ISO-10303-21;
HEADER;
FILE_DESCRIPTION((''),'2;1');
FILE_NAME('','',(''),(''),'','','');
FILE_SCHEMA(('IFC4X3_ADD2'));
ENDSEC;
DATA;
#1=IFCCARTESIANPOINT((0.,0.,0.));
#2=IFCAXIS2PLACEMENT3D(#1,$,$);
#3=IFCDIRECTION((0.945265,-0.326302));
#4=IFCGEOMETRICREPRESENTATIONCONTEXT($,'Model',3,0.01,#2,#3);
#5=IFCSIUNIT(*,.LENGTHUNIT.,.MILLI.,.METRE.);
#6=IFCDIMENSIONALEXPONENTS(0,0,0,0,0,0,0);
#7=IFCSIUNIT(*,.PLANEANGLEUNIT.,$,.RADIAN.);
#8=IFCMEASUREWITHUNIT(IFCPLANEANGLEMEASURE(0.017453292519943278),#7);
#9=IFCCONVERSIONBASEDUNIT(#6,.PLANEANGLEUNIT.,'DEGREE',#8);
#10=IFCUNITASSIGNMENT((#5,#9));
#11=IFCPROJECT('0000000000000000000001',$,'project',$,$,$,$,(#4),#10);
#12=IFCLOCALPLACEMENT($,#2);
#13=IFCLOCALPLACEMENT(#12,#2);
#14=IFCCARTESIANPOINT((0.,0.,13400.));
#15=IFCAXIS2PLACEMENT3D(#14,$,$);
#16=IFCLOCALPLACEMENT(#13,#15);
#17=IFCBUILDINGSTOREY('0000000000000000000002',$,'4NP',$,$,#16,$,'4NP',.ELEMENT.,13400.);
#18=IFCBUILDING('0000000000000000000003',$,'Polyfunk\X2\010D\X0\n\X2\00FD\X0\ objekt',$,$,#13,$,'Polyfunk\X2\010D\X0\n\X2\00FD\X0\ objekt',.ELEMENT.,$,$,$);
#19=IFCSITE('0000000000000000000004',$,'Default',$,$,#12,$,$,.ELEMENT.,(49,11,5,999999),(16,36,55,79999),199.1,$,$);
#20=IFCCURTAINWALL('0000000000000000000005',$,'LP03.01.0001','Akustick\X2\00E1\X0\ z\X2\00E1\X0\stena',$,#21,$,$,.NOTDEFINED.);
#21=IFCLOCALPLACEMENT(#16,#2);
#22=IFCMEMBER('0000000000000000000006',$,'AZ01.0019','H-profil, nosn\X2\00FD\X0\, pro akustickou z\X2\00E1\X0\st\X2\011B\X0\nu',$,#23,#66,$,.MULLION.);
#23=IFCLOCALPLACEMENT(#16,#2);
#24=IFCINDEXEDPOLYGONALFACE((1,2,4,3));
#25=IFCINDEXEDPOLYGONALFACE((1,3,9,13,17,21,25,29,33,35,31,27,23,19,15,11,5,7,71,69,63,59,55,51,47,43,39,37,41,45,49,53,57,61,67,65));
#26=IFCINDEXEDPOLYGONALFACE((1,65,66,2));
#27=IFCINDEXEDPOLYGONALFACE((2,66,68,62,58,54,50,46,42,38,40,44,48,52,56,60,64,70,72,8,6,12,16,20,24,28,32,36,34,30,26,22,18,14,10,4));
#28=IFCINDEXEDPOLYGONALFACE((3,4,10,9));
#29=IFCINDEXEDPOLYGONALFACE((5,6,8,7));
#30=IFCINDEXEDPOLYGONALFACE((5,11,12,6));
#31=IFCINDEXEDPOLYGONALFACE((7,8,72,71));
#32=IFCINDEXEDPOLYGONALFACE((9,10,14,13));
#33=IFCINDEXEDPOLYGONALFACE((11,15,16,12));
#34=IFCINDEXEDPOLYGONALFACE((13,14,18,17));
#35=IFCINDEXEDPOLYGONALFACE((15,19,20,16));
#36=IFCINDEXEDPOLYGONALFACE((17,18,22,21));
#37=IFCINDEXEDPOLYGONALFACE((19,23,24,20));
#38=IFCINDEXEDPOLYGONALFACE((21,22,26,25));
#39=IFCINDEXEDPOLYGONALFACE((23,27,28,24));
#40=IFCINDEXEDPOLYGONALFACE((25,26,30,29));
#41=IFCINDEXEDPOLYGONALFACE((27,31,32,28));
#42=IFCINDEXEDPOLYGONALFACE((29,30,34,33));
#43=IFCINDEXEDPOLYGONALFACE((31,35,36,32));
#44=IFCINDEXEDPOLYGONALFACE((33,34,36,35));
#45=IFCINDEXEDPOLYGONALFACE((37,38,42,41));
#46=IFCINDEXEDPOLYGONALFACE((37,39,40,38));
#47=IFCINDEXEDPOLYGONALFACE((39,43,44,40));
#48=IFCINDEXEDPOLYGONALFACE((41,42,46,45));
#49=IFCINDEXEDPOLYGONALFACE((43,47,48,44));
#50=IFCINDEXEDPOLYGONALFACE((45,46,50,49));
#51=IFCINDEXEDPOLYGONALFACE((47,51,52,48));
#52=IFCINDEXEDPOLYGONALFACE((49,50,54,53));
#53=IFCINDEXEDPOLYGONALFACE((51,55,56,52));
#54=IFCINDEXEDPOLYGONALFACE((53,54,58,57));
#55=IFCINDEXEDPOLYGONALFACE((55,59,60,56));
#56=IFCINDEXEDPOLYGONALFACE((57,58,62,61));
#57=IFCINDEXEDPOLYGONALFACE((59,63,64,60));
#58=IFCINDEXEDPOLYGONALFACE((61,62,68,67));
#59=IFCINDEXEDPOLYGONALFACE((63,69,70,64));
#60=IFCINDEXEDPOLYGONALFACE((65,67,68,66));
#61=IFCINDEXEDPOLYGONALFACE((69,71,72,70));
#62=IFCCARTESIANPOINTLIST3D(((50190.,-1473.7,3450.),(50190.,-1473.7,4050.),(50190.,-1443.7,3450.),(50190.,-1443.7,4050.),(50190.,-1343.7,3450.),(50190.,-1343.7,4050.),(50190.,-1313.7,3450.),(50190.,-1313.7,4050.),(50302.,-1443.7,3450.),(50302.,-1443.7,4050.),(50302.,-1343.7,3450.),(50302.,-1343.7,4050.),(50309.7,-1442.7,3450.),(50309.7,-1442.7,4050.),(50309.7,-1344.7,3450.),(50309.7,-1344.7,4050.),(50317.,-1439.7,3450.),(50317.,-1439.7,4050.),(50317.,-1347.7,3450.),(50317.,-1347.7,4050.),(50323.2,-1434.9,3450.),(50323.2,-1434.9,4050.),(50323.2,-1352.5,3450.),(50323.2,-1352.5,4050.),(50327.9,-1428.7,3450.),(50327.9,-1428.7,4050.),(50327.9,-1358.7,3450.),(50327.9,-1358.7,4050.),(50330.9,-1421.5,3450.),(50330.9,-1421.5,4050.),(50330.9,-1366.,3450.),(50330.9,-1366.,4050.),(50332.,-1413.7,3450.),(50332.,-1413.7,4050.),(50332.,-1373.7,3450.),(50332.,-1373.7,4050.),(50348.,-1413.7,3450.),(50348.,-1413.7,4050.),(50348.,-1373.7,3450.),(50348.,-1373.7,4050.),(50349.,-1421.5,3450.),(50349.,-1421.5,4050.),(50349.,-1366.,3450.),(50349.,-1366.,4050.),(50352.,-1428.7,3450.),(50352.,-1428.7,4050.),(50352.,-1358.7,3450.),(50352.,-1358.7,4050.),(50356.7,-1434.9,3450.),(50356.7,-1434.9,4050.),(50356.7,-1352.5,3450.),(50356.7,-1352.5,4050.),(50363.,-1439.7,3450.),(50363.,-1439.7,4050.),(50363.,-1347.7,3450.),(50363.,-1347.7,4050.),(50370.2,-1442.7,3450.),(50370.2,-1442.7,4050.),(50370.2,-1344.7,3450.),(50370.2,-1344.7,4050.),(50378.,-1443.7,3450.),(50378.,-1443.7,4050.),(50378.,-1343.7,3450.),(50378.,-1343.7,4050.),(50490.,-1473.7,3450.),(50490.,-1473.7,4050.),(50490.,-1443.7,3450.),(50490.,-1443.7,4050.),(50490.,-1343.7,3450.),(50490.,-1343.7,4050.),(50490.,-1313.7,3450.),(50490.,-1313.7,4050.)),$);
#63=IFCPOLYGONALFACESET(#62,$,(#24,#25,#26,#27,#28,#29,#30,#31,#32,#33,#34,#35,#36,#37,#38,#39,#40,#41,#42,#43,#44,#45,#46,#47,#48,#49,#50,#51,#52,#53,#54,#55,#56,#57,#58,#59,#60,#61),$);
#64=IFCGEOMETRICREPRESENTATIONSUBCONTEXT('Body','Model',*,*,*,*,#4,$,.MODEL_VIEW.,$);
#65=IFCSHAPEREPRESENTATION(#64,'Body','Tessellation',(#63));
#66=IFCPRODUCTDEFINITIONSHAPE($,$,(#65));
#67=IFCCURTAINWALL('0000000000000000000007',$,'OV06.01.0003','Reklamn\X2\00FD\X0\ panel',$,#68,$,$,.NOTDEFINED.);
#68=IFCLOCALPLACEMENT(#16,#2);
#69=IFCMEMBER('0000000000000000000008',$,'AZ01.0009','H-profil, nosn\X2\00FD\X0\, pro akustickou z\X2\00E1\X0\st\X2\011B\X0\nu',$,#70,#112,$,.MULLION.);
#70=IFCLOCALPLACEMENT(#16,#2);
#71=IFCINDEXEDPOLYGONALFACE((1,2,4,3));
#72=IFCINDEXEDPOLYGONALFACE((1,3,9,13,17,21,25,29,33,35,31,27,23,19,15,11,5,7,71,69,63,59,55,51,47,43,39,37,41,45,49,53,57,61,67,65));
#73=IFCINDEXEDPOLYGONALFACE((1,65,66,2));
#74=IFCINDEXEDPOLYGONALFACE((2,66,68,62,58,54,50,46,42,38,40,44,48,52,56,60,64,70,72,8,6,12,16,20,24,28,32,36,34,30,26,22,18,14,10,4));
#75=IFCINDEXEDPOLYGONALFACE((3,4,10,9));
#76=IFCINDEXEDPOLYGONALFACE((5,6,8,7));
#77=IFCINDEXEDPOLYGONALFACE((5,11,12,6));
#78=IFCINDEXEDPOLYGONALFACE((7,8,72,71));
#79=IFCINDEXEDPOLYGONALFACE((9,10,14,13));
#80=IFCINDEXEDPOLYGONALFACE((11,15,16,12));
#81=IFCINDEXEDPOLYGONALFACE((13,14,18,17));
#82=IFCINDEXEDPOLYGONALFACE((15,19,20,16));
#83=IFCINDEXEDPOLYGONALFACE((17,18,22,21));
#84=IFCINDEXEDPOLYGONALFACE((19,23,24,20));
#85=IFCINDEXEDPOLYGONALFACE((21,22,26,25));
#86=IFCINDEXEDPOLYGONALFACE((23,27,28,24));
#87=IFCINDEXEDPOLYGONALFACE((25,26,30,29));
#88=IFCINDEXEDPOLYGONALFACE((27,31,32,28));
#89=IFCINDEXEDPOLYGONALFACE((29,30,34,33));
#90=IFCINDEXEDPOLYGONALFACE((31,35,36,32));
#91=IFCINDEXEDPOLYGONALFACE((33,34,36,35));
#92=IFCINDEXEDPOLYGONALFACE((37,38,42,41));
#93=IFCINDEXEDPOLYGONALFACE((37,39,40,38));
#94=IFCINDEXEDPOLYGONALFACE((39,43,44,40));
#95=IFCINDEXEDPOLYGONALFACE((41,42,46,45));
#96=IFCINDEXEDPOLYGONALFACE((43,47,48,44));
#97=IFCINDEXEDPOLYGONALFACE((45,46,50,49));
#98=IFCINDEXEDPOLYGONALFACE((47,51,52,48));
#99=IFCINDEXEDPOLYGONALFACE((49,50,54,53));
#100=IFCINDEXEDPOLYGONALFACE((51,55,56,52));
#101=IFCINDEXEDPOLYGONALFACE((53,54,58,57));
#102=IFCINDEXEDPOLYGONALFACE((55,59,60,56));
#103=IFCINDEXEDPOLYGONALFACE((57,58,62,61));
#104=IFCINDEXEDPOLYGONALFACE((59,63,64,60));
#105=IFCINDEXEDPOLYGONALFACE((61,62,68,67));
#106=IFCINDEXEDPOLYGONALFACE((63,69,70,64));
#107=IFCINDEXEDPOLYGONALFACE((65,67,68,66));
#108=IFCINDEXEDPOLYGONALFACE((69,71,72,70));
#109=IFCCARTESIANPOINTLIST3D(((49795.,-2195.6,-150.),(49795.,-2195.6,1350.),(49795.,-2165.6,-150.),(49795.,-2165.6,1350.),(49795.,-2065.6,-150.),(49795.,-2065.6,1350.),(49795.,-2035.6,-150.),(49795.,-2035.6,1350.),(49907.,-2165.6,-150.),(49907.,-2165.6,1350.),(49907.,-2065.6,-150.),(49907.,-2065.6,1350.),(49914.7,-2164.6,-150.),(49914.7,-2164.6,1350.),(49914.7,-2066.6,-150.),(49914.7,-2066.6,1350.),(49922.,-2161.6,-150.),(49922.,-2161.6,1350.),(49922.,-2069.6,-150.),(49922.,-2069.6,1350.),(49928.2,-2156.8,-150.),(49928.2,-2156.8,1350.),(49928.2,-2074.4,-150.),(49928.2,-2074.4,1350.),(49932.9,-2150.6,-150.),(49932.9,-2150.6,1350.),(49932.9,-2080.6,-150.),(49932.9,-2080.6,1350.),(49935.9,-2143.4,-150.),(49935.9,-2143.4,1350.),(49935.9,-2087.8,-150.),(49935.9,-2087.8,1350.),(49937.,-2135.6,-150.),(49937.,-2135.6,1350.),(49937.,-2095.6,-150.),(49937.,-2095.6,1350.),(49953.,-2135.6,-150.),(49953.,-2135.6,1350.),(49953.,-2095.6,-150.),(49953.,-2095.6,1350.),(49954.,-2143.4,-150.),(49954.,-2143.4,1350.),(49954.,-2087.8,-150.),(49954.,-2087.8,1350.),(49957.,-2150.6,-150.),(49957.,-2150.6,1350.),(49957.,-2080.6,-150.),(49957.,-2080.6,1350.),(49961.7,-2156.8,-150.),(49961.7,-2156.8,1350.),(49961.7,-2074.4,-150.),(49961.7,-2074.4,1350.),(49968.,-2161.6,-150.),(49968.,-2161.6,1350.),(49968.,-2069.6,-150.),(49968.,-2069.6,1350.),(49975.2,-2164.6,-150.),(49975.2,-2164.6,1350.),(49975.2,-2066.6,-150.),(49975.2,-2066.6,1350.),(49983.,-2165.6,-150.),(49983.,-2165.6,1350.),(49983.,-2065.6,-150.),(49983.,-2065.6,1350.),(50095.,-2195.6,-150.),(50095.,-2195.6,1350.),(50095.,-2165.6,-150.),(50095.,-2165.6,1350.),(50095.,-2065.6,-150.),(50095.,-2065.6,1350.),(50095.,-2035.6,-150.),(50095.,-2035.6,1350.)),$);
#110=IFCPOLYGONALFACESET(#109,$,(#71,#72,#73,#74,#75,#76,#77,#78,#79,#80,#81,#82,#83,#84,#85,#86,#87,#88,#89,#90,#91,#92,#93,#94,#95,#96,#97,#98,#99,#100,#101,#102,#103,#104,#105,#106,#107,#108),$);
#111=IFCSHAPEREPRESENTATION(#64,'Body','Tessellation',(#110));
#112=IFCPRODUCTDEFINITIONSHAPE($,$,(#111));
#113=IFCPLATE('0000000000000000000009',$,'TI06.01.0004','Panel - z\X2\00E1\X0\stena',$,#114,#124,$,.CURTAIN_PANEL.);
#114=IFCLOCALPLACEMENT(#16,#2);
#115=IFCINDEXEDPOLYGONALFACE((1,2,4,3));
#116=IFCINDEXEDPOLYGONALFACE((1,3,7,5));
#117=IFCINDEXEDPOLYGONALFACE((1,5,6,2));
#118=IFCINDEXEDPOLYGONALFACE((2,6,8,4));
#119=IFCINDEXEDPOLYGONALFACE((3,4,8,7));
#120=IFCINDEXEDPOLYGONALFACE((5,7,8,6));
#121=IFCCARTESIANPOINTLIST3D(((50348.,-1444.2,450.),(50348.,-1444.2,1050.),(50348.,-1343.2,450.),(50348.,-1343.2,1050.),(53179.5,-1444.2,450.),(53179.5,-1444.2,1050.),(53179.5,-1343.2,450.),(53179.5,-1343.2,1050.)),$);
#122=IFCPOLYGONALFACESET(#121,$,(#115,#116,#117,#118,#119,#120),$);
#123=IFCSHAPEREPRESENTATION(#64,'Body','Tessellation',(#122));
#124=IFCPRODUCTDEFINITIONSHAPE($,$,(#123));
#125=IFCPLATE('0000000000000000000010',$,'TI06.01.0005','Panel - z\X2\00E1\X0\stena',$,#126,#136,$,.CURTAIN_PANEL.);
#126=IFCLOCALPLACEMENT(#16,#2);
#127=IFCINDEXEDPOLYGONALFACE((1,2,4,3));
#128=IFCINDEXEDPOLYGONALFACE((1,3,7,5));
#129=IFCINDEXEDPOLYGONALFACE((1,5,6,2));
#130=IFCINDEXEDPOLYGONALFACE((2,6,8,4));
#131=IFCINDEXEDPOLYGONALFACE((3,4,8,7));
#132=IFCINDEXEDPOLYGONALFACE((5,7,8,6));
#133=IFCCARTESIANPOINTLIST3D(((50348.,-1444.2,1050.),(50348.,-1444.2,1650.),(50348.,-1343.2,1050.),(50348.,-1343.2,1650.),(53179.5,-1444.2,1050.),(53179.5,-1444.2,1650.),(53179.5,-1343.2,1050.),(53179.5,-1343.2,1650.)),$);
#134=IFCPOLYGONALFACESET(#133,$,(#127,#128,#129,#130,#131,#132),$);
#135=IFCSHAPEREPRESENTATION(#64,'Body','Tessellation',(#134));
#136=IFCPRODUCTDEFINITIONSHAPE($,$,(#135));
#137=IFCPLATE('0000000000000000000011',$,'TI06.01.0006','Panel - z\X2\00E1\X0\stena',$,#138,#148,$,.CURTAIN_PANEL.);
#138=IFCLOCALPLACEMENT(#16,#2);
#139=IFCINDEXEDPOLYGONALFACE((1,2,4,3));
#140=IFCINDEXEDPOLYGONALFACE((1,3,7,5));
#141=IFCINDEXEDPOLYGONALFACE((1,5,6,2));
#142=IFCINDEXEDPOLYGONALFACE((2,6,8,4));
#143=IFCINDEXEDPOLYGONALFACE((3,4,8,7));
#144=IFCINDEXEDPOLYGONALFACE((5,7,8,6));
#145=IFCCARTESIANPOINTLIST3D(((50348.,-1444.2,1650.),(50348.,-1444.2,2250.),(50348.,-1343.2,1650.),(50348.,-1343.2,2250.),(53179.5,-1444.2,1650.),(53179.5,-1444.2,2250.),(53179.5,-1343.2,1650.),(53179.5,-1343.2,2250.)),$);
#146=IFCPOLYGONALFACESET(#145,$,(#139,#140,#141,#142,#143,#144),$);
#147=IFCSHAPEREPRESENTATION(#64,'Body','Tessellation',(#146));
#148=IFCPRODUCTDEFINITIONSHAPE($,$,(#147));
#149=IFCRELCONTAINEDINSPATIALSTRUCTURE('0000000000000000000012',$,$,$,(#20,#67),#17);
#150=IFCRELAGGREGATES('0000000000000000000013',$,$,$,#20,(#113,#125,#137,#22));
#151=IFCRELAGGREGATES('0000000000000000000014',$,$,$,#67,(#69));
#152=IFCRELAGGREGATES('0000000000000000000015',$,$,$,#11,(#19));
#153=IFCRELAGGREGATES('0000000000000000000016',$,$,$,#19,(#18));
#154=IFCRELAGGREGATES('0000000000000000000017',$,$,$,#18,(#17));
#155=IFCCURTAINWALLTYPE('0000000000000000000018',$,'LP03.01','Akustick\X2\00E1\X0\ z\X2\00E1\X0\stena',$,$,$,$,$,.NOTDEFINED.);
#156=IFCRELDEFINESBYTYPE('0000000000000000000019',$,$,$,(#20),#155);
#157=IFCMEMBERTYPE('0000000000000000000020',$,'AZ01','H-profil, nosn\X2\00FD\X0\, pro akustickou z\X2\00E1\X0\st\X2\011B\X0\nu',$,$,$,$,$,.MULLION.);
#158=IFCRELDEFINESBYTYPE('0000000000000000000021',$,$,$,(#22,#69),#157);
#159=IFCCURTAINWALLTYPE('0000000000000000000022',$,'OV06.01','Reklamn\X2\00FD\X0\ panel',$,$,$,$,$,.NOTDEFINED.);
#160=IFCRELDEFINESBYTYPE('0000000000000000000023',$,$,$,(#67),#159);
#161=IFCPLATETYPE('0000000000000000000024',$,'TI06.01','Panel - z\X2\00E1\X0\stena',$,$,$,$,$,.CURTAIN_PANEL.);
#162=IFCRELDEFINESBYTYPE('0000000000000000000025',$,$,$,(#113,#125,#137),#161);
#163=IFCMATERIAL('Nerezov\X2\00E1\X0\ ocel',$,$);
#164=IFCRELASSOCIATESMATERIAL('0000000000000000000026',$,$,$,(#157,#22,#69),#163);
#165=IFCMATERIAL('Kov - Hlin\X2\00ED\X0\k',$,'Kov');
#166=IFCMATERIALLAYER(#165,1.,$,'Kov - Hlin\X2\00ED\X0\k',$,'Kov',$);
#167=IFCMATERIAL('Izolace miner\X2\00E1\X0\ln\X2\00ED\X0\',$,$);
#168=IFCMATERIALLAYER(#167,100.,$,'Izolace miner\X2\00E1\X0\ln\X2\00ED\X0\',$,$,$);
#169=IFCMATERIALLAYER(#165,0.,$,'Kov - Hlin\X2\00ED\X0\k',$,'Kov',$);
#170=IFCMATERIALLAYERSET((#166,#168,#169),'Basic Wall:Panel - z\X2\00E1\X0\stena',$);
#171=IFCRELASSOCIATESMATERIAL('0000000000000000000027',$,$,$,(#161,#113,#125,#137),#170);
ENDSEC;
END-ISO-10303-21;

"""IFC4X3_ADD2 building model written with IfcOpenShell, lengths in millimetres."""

from ifc_helpers import new_model, entity, si_unit, converted_unit, direction, frame, frame_2d, origin, place, context, subcontext, project, spatial, polyline, circle_curve, parameter, trimmed, segment, composite_curve, rectangle, outline, extrude, source, transform, mapped, material, layer, layer_set, layer_usage, material_profile, profile_set, profile_usage, type_object, element, aggregate, save


model = new_model("IFC4X3_ADD2")

# Units and contexts
model_context = context("Model", 3, precision=0.01, world=origin(), true_north=direction((0.945265, -0.326302)))
body_context = subcontext(model_context, "Body", "Model", "MODEL_VIEW")
ifc_project = project(units=[si_unit("LENGTHUNIT", "METRE", prefix="MILLI"), converted_unit("PLANEANGLEUNIT", "DEGREE", entity("IfcPlaneAngleMeasure", 0.017453292519943278), si_unit("PLANEANGLEUNIT", "RADIAN"), dimensions=[0, 0, 0, 0, 0, 0, 0])], contexts=[model_context])

# Site, building, storey
site_placement = place(None, origin())
site = spatial("IfcSite", under=ifc_project, at=site_placement, Name="Default", CompositionType="ELEMENT", RefLatitude=(49, 11, 5, 999999), RefLongitude=(16, 36, 55, 79999), RefElevation=199.1)
building_placement = place(site_placement, origin())
building = spatial("IfcBuilding", under=site, at=building_placement, Name="Polyfunkčný objekt", LongName="Polyfunkčný objekt", CompositionType="ELEMENT")
storey_placement = place(building_placement, frame((0.0, 0.0, 13400.0)))
storey = spatial("IfcBuildingStorey", under=building, at=storey_placement, Name="4NP", LongName="4NP", CompositionType="ELEMENT", Elevation=13400.0)

# Curtain wall, member
curtain_wall_type_1 = type_object("IfcCurtainWallType", Name="LP03.01", Description="Akustická zástena", PredefinedType="NOTDEFINED")
curtain_wall_1_placement = place(storey_placement, frame((0.0, 0.0, -13400.0)))
curtain_wall_1 = element("IfcCurtainWall", 1, at=curtain_wall_1_placement, inside=storey, type_object=curtain_wall_type_1, Name="LP03.01.0001", Description="Akustická zástena", PredefinedType="NOTDEFINED")
ifc_material_1 = material(Name="Nerezová ocel")
ifc_material_profile = material_profile(ifc_material_1, outline(composite_curve([segment(polyline([(50.0, -150.0), (80.0, -150.0)]), True, "CONTINUOUS"), segment(polyline([(80.0, -150.0), (80.0, 150.0)]), True, "CONTINUOUS"), segment(polyline([(80.0, 150.0), (50.0, 150.0)]), True, "CONTINUOUS"), segment(polyline([(50.0, 150.0), (50.0, 38.0)]), True, "CONTINUOUS"), segment(trimmed(circle_curve(frame_2d((20.0, 38.0), x_axis=(0.0, 1.0)), 30.0), [parameter(180.0)], [parameter(270.0)], True, "PARAMETER"), False, "CONTINUOUS"), segment(polyline([(20.0, 8.0), (-20.0, 8.0)]), True, "CONTINUOUS"), segment(trimmed(circle_curve(frame_2d((-20.0, 38.0), x_axis=(0.0, 1.0)), 30.0), [parameter(90.0)], [parameter(180.0)], True, "PARAMETER"), False, "CONTINUOUS"), segment(polyline([(-50.0, 38.0), (-50.0, 150.0)]), True, "CONTINUOUS"), segment(polyline([(-50.0, 150.0), (-80.0, 150.0)]), True, "CONTINUOUS"), segment(polyline([(-80.0, 150.0), (-80.0, -150.0)]), True, "CONTINUOUS"), segment(polyline([(-80.0, -150.0), (-50.0, -150.0)]), True, "CONTINUOUS"), segment(polyline([(-50.0, -150.0), (-50.0, -38.0)]), True, "CONTINUOUS"), segment(trimmed(circle_curve(frame_2d((-20.0, -38.0), x_axis=(0.0, 1.0)), 30.0), [parameter(0.0)], [parameter(90.0)], True, "PARAMETER"), False, "CONTINUOUS"), segment(polyline([(-20.0, -8.0), (20.0, -8.0)]), True, "CONTINUOUS"), segment(trimmed(circle_curve(frame_2d((20.0, -38.0), x_axis=(0.0, 1.0)), 30.0), [parameter(270.0)], [parameter(0.0)], True, "PARAMETER"), False, "CONTINUOUS"), segment(polyline([(50.0, -38.0), (50.0, -150.0)]), True, "CONTINUOUS")], self_intersect=False)), Name="Profil zástena")
ifc_profile_set = profile_set([ifc_material_profile], Name="Profil zástena")
ifc_profile_usage = profile_usage(ifc_profile_set)
member_type = type_object("IfcMemberType", Name="AZ01", Description="H-profil, nosný, pro akustickou zástěnu", PredefinedType="MULLION", material=ifc_profile_set)
shared_shape_1 = source(origin(), body_context, "Body", "SweptSolid", [
    extrude(outline(composite_curve([segment(polyline([(-150.0, -50.0), (-150.0, -80.0)]), True, "CONTINUOUS"), segment(polyline([(-150.0, -80.0), (150.0, -80.0)]), True, "CONTINUOUS"), segment(polyline([(150.0, -80.0), (150.0, -50.0)]), True, "CONTINUOUS"), segment(polyline([(150.0, -50.0), (38.0, -50.0)]), True, "CONTINUOUS"), segment(trimmed(circle_curve(frame_2d((38.0, -20.0), x_axis=(1.0, 0.0)), 30.0), [parameter(180.0)], [parameter(270.0)], True, "PARAMETER"), False, "CONTINUOUS"), segment(polyline([(8.0, -20.0), (8.0, 20.0)]), True, "CONTINUOUS"), segment(trimmed(circle_curve(frame_2d((38.0, 20.0), x_axis=(1.0, 0.0)), 30.0), [parameter(90.0)], [parameter(180.0)], True, "PARAMETER"), False, "CONTINUOUS"), segment(polyline([(38.0, 50.0), (150.0, 50.0)]), True, "CONTINUOUS"), segment(polyline([(150.0, 50.0), (150.0, 80.0)]), True, "CONTINUOUS"), segment(polyline([(150.0, 80.0), (-150.0, 80.0)]), True, "CONTINUOUS"), segment(polyline([(-150.0, 80.0), (-150.0, 50.0)]), True, "CONTINUOUS"), segment(polyline([(-150.0, 50.0), (-38.0, 50.0)]), True, "CONTINUOUS"), segment(trimmed(circle_curve(frame_2d((-38.0, 20.0), x_axis=(1.0, 0.0)), 30.0), [parameter(0.0)], [parameter(90.0)], True, "PARAMETER"), False, "CONTINUOUS"), segment(polyline([(-8.0, 20.0), (-8.0, -20.0)]), True, "CONTINUOUS"), segment(trimmed(circle_curve(frame_2d((-38.0, -20.0), x_axis=(1.0, 0.0)), 30.0), [parameter(270.0)], [parameter(0.0)], True, "PARAMETER"), False, "CONTINUOUS"), segment(polyline([(-38.0, -50.0), (-150.0, -50.0)]), True, "CONTINUOUS")], self_intersect=False)), frame((-150.0, 0.0, -600.0), z_axis=(0.0, 0.0, -1.0), x_axis=(-1.0, 0.0, 0.0)), (0.0, 0.0, -1.0), 600.0),
])
member_1_placement = place(curtain_wall_1_placement, frame((50190.0, -1393.7, 17450.0), z_axis=(0.0, 0.0, 1.0), x_axis=(-1.0, 0.0, 0.0)))
member_1 = element("IfcMember", 2, at=member_1_placement, type_object=member_type, material=ifc_profile_usage, Name="AZ01.0019", Description="H-profil, nosný, pro akustickou zástěnu", PredefinedType="MULLION", context=body_context, shape_type="MappedRepresentation", body=[
    mapped(shared_shape_1, transform((0.0, 0.0, 0.0), scale=1.0)),
])

# Curtain wall, member
curtain_wall_type_2 = type_object("IfcCurtainWallType", Name="OV06.01", Description="Reklamný panel", PredefinedType="NOTDEFINED")
curtain_wall_2_placement = place(storey_placement, frame((0.0, 0.0, -13400.0)))
curtain_wall_2 = element("IfcCurtainWall", 3, at=curtain_wall_2_placement, inside=storey, type_object=curtain_wall_type_2, Name="OV06.01.0003", Description="Reklamný panel", PredefinedType="NOTDEFINED")
shared_shape_2 = source(origin(), body_context, "Body", "SweptSolid", [
    extrude(outline(composite_curve([segment(polyline([(50.0, -150.0), (80.0, -150.0)]), True, "CONTINUOUS"), segment(polyline([(80.0, -150.0), (80.0, 150.0)]), True, "CONTINUOUS"), segment(polyline([(80.0, 150.0), (50.0, 150.0)]), True, "CONTINUOUS"), segment(polyline([(50.0, 150.0), (50.0, 38.0)]), True, "CONTINUOUS"), segment(trimmed(circle_curve(frame_2d((20.0, 38.0), x_axis=(0.0, 1.0)), 30.0), [parameter(180.0)], [parameter(270.0)], True, "PARAMETER"), False, "CONTINUOUS"), segment(polyline([(20.0, 8.0), (-20.0, 8.0)]), True, "CONTINUOUS"), segment(trimmed(circle_curve(frame_2d((-20.0, 38.0), x_axis=(0.0, 1.0)), 30.0), [parameter(90.0)], [parameter(180.0)], True, "PARAMETER"), False, "CONTINUOUS"), segment(polyline([(-50.0, 38.0), (-50.0, 150.0)]), True, "CONTINUOUS"), segment(polyline([(-50.0, 150.0), (-80.0, 150.0)]), True, "CONTINUOUS"), segment(polyline([(-80.0, 150.0), (-80.0, -150.0)]), True, "CONTINUOUS"), segment(polyline([(-80.0, -150.0), (-50.0, -150.0)]), True, "CONTINUOUS"), segment(polyline([(-50.0, -150.0), (-50.0, -38.0)]), True, "CONTINUOUS"), segment(trimmed(circle_curve(frame_2d((-20.0, -38.0), x_axis=(0.0, 1.0)), 30.0), [parameter(0.0)], [parameter(90.0)], True, "PARAMETER"), False, "CONTINUOUS"), segment(polyline([(-20.0, -8.0), (20.0, -8.0)]), True, "CONTINUOUS"), segment(trimmed(circle_curve(frame_2d((20.0, -38.0), x_axis=(0.0, 1.0)), 30.0), [parameter(270.0)], [parameter(0.0)], True, "PARAMETER"), False, "CONTINUOUS"), segment(polyline([(50.0, -38.0), (50.0, -150.0)]), True, "CONTINUOUS")], self_intersect=False)), frame((-150.0, 0.0, -1500.0), z_axis=(0.0, 0.0, 1.0), x_axis=(0.0, 1.0, 0.0)), (0.0, 0.0, 1.0), 1500.0),
])
member_2_placement = place(curtain_wall_2_placement, frame((49795.0, -2115.6, 14750.0), z_axis=(0.0, 0.0, 1.0), x_axis=(-1.0, 0.0, 0.0)))
member_2 = element("IfcMember", 4, at=member_2_placement, type_object=member_type, material=ifc_profile_usage, Name="AZ01.0009", Description="H-profil, nosný, pro akustickou zástěnu", PredefinedType="MULLION", context=body_context, shape_type="MappedRepresentation", body=[
    mapped(shared_shape_2, transform((0.0, 0.0, 0.0), scale=1.0)),
])

# Plates
ifc_material_2 = material(Name="Kov - Hliník", Category="Kov")
ifc_layer_1 = layer(ifc_material_2, 1.0, Name="Kov - Hliník", Category="Kov")
ifc_material_3 = material(Name="Izolace minerální")
ifc_layer_2 = layer(ifc_material_3, 100.0, Name="Izolace minerální")
ifc_layer_3 = layer(ifc_material_2, 0.0, Name="Kov - Hliník", Category="Kov")
ifc_layer_set_1 = layer_set([ifc_layer_1, ifc_layer_2, ifc_layer_3], Name="Basic Wall:Panel - zástena")
ifc_layer_usage_1 = layer_usage(ifc_layer_set_1, "AXIS2", "POSITIVE", -50.5)
plate_type = type_object("IfcPlateType", Name="TI06.01", Description="Panel - zástena", PredefinedType="CURTAIN_PANEL", material=ifc_layer_set_1)
plate_1_placement = place(storey_placement, frame((50348.0, -1393.7, 450.0)))
plate_1 = element("IfcPlate", 5, at=plate_1_placement, type_object=plate_type, material=ifc_layer_usage_1, Name="TI06.01.0004", Description="Panel - zástena", PredefinedType="CURTAIN_PANEL", context=body_context, shape_type="SweptSolid", body=[
    extrude(rectangle(XDim=101.0, YDim=2831.5, at=frame_2d((0.0, 0.0), x_axis=(1.0, 0.0))), frame((1415.8, 0.0, 0.0), z_axis=(0.0, 0.0, 1.0), x_axis=(0.0, 1.0, 0.0)), (0.0, 0.0, 1.0), 600.0),
])
ifc_layer_usage_2 = layer_usage(ifc_layer_set_1, "AXIS2", "POSITIVE", -50.5)
plate_2_placement = place(storey_placement, frame((50348.0, -1393.7, 1050.0)))
plate_2 = element("IfcPlate", 6, at=plate_2_placement, type_object=plate_type, material=ifc_layer_usage_2, Name="TI06.01.0005", Description="Panel - zástena", PredefinedType="CURTAIN_PANEL", context=body_context, shape_type="SweptSolid", body=[
    extrude(rectangle(XDim=101.0, YDim=2831.5, at=frame_2d((0.0, 0.0), x_axis=(1.0, 0.0))), frame((1415.8, 0.0, 0.0), z_axis=(0.0, 0.0, 1.0), x_axis=(0.0, 1.0, 0.0)), (0.0, 0.0, 1.0), 600.0),
])
ifc_layer_usage_3 = layer_usage(ifc_layer_set_1, "AXIS2", "POSITIVE", -50.5)
plate_3_placement = place(storey_placement, frame((50348.0, -1393.7, 1650.0)))
plate_3 = element("IfcPlate", 7, at=plate_3_placement, type_object=plate_type, material=ifc_layer_usage_3, Name="TI06.01.0006", Description="Panel - zástena", PredefinedType="CURTAIN_PANEL", context=body_context, shape_type="SweptSolid", body=[
    extrude(rectangle(XDim=101.0, YDim=2831.5, at=frame_2d((0.0, 0.0), x_axis=(1.0, 0.0))), frame((1415.8, 0.0, 0.0), z_axis=(0.0, 0.0, 1.0), x_axis=(0.0, 1.0, 0.0)), (0.0, 0.0, 1.0), 600.0),
])
aggregate(curtain_wall_1, [plate_1, plate_2, plate_3, member_1])
aggregate(curtain_wall_2, [member_2])

save(model, "model.ifc")
